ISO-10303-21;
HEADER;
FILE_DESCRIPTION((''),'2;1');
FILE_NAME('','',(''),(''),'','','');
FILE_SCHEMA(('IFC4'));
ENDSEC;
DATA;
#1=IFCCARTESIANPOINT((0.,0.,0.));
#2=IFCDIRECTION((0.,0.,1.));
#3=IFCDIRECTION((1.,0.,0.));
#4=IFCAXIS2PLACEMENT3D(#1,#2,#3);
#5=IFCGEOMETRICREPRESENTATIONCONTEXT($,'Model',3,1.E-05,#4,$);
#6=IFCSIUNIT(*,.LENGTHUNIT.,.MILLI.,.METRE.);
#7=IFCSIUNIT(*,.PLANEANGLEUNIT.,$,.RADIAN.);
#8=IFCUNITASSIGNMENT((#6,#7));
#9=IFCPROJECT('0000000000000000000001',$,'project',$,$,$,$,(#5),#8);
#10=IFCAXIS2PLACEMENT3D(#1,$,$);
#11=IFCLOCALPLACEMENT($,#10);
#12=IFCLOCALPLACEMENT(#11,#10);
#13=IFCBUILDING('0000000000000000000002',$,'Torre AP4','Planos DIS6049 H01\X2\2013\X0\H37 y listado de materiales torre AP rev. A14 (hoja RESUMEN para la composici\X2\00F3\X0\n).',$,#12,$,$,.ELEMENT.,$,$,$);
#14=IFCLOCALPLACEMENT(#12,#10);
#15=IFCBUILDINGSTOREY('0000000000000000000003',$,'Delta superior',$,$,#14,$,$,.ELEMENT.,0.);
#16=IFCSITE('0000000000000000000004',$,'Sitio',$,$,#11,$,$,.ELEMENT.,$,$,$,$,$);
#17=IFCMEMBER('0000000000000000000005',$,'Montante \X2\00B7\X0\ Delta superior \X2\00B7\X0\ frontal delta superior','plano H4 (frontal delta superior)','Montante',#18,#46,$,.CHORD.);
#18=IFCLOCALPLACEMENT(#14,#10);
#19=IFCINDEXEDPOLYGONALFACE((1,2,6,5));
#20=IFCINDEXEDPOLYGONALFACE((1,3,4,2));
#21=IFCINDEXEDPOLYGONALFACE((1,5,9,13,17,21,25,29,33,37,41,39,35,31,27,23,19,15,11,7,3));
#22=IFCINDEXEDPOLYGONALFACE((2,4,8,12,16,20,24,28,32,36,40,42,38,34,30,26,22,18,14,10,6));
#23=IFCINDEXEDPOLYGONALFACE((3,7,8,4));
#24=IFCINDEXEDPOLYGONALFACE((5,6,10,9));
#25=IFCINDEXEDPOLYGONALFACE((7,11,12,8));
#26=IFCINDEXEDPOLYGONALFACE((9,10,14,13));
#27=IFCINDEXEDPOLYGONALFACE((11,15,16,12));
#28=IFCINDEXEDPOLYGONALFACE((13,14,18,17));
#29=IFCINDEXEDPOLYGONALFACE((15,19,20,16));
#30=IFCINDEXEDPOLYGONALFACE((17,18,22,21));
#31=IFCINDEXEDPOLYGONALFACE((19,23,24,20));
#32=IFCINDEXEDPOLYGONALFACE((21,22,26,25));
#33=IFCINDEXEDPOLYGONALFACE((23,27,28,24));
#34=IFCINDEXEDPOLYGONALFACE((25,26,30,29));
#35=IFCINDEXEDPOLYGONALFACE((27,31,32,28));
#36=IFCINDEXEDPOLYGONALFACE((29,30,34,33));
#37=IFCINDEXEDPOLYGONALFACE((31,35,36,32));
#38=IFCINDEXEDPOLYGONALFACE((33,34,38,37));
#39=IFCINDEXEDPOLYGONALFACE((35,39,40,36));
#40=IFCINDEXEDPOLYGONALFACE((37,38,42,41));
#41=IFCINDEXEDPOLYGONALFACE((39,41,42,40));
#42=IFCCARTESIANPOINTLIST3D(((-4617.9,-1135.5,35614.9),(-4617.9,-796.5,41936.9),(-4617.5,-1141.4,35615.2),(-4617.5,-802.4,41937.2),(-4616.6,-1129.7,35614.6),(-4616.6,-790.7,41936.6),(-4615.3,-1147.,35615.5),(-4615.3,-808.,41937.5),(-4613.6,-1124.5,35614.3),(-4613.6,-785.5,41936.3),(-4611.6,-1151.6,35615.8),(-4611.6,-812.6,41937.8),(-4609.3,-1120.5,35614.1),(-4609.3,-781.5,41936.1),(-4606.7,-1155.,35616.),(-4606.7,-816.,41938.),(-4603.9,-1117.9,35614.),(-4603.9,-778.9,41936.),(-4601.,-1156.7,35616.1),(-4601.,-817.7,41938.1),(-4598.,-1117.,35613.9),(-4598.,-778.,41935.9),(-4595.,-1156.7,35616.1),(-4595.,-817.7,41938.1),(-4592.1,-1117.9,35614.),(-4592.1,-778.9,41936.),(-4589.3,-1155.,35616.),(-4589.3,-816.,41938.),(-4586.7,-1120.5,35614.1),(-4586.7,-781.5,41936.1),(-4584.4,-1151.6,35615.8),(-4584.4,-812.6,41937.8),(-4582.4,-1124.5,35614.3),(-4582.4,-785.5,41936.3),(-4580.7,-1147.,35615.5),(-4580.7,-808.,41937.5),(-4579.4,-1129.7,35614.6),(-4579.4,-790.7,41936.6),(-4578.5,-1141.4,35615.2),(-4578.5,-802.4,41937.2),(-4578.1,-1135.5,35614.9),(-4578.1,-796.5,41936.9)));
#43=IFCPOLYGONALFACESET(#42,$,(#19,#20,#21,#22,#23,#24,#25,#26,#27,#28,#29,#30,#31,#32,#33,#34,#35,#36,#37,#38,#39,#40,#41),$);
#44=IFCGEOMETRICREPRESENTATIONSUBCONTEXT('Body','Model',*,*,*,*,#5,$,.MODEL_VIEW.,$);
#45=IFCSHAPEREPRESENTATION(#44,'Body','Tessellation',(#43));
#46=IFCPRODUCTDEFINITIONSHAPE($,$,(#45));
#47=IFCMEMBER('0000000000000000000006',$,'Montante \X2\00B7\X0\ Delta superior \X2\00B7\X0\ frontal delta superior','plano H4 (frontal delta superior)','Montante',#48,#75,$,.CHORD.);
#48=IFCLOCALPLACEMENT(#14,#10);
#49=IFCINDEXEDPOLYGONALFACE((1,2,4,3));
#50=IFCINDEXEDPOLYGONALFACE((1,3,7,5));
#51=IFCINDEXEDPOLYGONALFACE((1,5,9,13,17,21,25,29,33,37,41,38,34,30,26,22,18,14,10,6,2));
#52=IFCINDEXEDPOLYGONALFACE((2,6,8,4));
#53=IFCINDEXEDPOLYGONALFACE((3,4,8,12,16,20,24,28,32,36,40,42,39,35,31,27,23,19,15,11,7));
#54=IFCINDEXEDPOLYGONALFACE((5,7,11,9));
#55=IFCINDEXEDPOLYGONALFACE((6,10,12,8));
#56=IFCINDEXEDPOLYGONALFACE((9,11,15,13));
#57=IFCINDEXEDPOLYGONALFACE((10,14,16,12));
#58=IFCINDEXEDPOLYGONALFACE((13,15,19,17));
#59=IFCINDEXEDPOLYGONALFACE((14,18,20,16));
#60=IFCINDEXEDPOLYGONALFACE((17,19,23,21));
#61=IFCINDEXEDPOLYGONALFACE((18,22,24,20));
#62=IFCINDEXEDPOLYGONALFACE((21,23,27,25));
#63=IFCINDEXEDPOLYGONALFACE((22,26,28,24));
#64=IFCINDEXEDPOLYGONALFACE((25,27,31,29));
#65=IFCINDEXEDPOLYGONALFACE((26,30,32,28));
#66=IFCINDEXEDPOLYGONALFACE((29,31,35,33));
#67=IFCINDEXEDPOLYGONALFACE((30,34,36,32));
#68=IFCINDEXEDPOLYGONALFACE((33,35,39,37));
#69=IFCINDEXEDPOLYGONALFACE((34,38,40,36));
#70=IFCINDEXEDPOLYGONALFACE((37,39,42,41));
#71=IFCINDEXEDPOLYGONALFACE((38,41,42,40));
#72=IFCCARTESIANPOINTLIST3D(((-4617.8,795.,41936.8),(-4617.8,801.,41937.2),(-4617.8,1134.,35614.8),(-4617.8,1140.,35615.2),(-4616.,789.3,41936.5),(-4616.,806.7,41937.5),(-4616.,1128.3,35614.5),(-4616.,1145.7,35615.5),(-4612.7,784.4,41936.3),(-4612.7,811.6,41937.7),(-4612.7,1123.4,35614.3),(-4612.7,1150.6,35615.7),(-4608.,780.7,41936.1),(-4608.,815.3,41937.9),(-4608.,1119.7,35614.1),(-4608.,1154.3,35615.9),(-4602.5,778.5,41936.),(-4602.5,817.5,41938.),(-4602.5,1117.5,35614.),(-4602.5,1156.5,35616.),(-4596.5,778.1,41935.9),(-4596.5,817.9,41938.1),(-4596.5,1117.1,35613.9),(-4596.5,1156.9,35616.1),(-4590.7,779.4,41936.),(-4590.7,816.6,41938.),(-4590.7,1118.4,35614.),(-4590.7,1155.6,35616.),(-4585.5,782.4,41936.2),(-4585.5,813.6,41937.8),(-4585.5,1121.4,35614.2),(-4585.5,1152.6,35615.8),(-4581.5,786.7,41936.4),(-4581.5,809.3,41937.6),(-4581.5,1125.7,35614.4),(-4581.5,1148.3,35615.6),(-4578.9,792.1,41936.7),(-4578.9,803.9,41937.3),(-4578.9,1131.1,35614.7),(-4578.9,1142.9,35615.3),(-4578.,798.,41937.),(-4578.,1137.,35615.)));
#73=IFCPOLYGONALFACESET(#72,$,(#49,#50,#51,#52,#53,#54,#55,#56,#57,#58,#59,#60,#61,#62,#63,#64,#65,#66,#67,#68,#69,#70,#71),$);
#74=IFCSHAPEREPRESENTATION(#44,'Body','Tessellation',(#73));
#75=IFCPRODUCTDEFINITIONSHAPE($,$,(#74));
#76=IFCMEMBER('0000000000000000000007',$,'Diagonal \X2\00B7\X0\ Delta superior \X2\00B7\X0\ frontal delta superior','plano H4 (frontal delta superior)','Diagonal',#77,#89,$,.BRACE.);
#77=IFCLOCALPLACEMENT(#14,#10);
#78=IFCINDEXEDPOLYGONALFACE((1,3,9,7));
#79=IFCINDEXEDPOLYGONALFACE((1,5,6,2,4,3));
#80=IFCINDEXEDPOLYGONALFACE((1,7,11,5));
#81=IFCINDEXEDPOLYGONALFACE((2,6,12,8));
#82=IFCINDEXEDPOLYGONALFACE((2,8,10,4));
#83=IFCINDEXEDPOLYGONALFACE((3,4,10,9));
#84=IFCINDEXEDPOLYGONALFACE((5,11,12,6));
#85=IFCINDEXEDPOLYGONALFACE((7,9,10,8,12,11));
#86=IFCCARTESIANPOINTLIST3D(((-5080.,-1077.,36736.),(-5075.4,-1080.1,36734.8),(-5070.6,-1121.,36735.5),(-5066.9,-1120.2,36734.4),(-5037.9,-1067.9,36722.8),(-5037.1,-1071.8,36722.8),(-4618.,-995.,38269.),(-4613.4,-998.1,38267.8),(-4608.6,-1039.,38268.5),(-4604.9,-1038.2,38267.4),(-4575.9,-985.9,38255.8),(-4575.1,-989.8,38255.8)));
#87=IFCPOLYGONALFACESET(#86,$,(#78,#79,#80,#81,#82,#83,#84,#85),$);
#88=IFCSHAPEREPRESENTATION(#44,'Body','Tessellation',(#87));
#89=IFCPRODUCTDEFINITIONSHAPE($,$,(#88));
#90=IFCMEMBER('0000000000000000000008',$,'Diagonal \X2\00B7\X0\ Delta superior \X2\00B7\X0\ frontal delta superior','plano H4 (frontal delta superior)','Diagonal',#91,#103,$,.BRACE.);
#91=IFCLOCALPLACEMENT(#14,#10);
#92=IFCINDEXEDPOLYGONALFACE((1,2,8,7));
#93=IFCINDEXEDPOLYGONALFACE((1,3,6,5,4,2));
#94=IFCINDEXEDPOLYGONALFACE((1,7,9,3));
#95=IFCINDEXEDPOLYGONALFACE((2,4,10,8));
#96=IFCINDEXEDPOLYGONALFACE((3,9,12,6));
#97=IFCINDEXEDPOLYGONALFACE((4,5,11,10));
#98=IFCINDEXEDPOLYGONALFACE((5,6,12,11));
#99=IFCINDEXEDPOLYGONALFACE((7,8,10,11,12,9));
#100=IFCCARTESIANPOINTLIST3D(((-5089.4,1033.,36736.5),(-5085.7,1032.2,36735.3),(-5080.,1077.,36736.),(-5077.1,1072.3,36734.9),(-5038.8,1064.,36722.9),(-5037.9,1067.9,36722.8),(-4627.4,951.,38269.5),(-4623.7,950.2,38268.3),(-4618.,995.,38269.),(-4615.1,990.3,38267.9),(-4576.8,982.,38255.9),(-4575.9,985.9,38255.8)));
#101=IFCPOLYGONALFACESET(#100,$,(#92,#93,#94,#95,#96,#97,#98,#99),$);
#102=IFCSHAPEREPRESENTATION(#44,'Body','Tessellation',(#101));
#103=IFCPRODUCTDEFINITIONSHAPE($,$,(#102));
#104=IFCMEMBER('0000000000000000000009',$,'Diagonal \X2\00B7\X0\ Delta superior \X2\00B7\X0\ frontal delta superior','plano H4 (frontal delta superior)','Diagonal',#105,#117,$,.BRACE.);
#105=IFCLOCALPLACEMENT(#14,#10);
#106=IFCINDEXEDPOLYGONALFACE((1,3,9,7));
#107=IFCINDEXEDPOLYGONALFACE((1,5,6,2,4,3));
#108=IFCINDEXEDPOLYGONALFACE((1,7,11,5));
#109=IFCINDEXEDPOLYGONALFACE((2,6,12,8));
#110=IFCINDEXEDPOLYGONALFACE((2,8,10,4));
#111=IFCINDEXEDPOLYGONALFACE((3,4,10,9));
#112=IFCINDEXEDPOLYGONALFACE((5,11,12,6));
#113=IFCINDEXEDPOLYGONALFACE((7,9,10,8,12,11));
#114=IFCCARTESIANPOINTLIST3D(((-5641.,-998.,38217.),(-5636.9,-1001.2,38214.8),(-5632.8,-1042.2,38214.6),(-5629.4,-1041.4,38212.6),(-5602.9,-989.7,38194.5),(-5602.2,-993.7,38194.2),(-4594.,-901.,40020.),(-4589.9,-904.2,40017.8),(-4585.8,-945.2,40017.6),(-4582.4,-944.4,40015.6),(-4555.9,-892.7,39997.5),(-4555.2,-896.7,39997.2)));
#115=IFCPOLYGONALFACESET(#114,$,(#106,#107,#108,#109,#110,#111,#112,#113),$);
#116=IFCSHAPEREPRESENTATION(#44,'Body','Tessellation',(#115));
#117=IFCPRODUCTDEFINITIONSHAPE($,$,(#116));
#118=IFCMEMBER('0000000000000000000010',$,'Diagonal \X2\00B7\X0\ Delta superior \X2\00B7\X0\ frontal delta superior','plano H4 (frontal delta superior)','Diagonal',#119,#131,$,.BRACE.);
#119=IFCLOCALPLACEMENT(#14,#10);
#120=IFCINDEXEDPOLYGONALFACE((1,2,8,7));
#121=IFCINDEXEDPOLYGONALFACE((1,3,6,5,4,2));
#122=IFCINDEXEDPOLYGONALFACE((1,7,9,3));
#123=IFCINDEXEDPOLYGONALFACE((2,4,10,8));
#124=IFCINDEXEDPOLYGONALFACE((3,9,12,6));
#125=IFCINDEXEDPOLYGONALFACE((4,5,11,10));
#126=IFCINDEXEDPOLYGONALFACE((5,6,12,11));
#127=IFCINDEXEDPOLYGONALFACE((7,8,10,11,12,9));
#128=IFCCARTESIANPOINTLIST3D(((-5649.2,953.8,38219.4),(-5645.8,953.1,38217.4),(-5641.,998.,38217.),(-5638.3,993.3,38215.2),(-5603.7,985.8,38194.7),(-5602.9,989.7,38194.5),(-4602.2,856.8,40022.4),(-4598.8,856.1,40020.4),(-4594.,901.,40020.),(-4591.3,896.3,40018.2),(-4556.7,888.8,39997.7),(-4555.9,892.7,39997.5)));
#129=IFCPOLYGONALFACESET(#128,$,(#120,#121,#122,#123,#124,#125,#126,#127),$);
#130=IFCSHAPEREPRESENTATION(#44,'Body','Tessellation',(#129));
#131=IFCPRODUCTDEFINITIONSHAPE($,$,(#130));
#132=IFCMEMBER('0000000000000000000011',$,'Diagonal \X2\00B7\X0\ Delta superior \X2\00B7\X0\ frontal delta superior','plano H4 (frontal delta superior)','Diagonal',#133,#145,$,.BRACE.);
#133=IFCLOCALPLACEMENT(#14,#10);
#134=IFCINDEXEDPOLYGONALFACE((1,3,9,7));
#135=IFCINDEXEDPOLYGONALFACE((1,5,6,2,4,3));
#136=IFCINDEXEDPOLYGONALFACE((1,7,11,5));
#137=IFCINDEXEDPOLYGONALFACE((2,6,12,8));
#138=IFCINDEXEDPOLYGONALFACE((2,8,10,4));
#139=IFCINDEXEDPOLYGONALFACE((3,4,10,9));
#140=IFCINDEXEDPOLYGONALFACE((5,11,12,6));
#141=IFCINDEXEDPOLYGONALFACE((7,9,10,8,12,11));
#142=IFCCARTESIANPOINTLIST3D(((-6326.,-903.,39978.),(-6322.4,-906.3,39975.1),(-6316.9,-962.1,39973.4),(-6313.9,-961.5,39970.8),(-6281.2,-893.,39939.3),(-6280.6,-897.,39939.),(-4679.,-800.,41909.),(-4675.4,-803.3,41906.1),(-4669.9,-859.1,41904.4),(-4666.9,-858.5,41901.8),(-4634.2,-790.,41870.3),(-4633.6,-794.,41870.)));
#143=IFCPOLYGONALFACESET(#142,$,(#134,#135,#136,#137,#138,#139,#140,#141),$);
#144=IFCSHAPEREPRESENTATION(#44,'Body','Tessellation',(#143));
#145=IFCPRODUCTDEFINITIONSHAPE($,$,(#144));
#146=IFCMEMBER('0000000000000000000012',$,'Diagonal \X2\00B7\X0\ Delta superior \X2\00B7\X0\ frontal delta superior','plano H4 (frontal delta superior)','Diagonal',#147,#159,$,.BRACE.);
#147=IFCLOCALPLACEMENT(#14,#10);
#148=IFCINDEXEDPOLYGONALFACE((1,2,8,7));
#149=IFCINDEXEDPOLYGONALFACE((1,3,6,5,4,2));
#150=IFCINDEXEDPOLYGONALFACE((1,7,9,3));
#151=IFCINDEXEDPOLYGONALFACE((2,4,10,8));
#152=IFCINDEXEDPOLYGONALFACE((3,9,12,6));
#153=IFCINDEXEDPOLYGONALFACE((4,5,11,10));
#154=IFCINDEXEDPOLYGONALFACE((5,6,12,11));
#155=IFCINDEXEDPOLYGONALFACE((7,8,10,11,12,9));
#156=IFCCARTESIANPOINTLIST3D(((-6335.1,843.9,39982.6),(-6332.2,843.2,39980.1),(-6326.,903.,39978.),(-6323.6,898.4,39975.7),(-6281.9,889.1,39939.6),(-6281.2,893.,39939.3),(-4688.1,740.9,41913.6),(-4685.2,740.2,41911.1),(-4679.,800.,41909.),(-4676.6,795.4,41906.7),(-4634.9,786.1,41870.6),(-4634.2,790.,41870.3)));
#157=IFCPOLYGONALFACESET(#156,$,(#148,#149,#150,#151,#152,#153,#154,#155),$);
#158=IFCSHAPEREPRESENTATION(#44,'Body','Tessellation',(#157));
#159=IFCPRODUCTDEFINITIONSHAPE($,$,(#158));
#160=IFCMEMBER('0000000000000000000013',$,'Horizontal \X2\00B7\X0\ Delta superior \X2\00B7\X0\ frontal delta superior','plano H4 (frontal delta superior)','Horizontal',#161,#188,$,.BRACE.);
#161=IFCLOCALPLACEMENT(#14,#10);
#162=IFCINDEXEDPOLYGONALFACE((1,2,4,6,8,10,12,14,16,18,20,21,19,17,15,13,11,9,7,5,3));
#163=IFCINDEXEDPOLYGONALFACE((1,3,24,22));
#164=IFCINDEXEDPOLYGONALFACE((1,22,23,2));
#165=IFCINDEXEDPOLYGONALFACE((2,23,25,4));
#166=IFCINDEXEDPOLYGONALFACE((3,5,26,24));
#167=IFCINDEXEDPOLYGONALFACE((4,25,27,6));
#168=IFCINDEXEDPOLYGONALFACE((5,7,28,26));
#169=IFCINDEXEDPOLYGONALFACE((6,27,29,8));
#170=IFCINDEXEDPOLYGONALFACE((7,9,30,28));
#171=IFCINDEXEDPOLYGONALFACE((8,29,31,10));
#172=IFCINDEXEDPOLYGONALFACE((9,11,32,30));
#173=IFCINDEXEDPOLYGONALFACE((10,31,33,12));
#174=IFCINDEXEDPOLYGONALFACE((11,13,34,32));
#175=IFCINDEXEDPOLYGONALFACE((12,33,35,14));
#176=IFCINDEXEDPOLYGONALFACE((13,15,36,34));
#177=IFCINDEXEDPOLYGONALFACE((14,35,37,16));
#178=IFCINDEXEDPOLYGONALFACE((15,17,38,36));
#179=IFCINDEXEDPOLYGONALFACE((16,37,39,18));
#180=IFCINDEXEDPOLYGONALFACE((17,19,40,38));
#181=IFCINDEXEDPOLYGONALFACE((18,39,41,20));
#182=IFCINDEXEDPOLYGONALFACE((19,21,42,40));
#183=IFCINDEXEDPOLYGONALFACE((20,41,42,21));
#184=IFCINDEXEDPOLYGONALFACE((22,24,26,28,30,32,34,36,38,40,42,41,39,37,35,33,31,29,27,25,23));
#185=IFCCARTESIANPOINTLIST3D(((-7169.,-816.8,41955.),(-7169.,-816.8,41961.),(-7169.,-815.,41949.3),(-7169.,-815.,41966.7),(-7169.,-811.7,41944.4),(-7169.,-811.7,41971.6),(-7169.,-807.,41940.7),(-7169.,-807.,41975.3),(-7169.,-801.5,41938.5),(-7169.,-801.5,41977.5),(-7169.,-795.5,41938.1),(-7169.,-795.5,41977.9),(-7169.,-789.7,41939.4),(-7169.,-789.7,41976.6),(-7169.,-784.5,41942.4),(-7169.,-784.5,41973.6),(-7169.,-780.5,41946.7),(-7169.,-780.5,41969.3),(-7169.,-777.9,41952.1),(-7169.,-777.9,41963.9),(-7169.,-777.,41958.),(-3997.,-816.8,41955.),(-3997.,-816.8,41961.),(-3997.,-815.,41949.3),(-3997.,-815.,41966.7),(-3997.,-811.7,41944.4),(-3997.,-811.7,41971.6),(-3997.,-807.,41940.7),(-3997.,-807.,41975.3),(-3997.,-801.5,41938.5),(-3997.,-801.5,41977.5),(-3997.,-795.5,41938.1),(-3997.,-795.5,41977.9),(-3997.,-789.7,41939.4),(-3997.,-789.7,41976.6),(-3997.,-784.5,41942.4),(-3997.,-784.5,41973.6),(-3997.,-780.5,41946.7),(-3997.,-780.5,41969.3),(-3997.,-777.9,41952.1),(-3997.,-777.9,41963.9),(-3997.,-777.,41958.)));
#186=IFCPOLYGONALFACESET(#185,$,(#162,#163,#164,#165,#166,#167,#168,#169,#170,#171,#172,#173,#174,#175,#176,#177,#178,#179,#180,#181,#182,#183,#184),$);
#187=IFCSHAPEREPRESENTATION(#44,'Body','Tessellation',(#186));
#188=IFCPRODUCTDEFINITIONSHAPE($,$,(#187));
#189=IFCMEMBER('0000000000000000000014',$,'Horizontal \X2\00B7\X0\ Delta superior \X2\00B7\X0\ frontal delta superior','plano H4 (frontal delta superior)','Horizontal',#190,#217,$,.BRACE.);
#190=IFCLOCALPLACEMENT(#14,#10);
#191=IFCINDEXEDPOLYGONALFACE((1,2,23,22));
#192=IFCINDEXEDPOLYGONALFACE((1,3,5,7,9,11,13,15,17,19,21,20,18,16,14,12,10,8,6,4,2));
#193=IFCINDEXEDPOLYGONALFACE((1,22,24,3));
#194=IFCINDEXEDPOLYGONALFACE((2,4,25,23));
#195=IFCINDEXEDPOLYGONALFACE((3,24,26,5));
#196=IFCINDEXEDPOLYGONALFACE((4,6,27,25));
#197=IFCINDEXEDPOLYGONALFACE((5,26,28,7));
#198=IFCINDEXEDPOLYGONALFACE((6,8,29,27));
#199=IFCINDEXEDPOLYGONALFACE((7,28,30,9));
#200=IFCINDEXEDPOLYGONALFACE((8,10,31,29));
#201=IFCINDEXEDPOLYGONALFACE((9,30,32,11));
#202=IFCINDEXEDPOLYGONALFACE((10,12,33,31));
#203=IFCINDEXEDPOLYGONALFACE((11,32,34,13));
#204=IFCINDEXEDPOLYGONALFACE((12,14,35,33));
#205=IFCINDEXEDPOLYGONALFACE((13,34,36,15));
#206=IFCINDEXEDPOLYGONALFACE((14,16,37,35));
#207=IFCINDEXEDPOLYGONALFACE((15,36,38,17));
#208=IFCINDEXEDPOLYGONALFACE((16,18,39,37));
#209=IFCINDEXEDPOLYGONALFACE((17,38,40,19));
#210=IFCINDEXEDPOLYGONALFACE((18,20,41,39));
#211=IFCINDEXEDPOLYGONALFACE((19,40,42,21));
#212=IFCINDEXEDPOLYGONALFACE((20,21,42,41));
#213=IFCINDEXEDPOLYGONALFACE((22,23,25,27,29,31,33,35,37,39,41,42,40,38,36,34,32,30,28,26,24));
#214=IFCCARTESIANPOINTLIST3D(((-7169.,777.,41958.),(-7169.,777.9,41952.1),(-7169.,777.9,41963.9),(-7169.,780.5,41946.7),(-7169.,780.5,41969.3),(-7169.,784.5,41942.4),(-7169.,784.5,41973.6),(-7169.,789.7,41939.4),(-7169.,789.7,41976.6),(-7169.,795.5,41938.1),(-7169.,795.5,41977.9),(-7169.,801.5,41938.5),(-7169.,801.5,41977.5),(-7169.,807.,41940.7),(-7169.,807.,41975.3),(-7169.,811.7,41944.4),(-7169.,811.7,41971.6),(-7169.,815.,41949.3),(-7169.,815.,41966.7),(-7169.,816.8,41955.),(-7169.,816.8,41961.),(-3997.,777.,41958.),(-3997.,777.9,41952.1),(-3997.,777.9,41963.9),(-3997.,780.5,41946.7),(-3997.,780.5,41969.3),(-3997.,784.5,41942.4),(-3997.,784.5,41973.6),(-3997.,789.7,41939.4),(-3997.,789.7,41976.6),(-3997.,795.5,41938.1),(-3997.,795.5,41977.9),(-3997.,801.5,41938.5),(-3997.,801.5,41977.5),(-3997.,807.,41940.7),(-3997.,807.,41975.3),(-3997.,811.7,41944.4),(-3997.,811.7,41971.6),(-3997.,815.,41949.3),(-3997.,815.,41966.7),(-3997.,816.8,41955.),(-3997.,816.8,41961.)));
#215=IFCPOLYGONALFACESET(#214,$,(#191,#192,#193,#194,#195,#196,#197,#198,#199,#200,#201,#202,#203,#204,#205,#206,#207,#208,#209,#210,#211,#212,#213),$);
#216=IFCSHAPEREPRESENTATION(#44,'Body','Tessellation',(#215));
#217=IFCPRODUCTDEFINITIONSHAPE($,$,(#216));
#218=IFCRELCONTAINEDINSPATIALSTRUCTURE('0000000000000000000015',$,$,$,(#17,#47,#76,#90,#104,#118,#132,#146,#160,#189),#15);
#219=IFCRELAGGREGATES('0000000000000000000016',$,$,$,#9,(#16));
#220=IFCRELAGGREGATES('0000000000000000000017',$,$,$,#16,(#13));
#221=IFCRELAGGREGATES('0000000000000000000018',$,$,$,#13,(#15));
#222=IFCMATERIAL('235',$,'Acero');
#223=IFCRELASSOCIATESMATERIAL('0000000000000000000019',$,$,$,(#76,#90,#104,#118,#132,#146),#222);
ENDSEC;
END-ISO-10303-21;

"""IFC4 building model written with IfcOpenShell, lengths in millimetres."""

from ifc_helpers import new_model, si_unit, frame, frame_2d, origin, origin_with_axes, place, context, subcontext, project, spatial, circle, l_section, extrude, material, element, save


model = new_model("IFC4")

# Units and contexts
model_context = context("Model", 3, precision=1e-05, world=origin_with_axes())
body_context = subcontext(model_context, "Body", "Model", "MODEL_VIEW")
ifc_project = project(units=[si_unit("LENGTHUNIT", "METRE", prefix="MILLI"), si_unit("PLANEANGLEUNIT", "RADIAN")], contexts=[model_context])

# Site, building, storey
site_placement = place(None, origin())
site = spatial("IfcSite", under=ifc_project, at=site_placement, Name="Sitio", CompositionType="ELEMENT")
building_placement = place(site_placement, origin())
building = spatial("IfcBuilding", under=site, at=building_placement, Name="Torre AP4", Description="Planos DIS6049 H01–H37 y listado de materiales torre AP rev. A14 (hoja RESUMEN para la composición).", CompositionType="ELEMENT")
storey_placement = place(building_placement, origin())
storey = spatial("IfcBuildingStorey", under=building, at=storey_placement, Name="Delta superior", CompositionType="ELEMENT", Elevation=0.0)

# Members
for number, where, z_axis, x_axis, name in (
    (1, (-4598.0, -798.0, 41937.0), (0.0, -0.053545, -0.998565), (0.0, 0.998565, -0.053545), "Montante · Delta superior · frontal delta superior"),
    (2, (-4598.0, 798.0, 41937.0), (0.0, 0.053545, -0.998565), (1.0, 0.0, 0.0), "Montante · Delta superior · frontal delta superior"),
):
    element("IfcMember", number, at=place(storey_placement, frame(where, z_axis=z_axis, x_axis=x_axis)), inside=storey, Name=name, Description="plano H4 (frontal delta superior)", ObjectType="Montante", PredefinedType="CHORD", context=body_context, shape_type="SweptSolid", body=[
        extrude(circle(Radius=20.0), None, (0.0, 0.0, 1.0), 6331.1),
    ])
ifc_material_1 = material(Name="235", Category="Acero")
for number, where, z_axis, x_axis, name in (
    (3, (-4618.0, -995.0, 38269.0), (-0.288173, -0.051148, -0.956211), (0.934509, 0.202848, -0.292483), "Diagonal · Delta superior · frontal delta superior"),
    (4, (-4618.0, 995.0, 38269.0), (-0.288173, 0.051148, -0.956211), (0.934509, -0.202848, -0.292483), "Diagonal · Delta superior · frontal delta superior"),
):
    element("IfcMember", number, at=place(storey_placement, frame(where, z_axis=z_axis, x_axis=x_axis)), inside=storey, material=ifc_material_1, Name=name, Description="plano H4 (frontal delta superior)", ObjectType="Diagonal", PredefinedType="BRACE", context=body_context, shape_type="SweptSolid", body=[
        extrude(l_section(Depth=45.0, Width=45.0, Thickness=4.0, at=frame_2d((22.5, 22.5))), None, (0.0, 0.0, 1.0), 1603.2),
    ])
for number, where, z_axis, x_axis, name in (
    (5, (-4594.0, -901.0, 40020.0), (-0.501628, -0.046474, -0.863834), (0.845685, 0.183933, -0.500984), "Diagonal · Delta superior · frontal delta superior"),
    (6, (-4594.0, 901.0, 40020.0), (-0.501628, 0.046474, -0.863834), (0.845685, -0.183933, -0.500984), "Diagonal · Delta superior · frontal delta superior"),
):
    element("IfcMember", number, at=place(storey_placement, frame(where, z_axis=z_axis, x_axis=x_axis)), inside=storey, material=ifc_material_1, Name=name, Description="plano H4 (frontal delta superior)", ObjectType="Diagonal", PredefinedType="BRACE", context=body_context, shape_type="SweptSolid", body=[
        extrude(l_section(Depth=45.0, Width=45.0, Thickness=4.0, at=frame_2d((22.5, 22.5))), None, (0.0, 0.0, 1.0), 2087.2),
    ])
for number, where, z_axis, x_axis, name in (
    (7, (-4679.0, -800.0, 41909.0), (-0.648406, -0.04055, -0.760214), (0.745871, 0.166153, -0.645035), "Diagonal · Delta superior · frontal delta superior"),
    (8, (-4679.0, 800.0, 41909.0), (-0.648406, 0.04055, -0.760214), (0.745871, -0.166153, -0.645035), "Diagonal · Delta superior · frontal delta superior"),
):
    element("IfcMember", number, at=place(storey_placement, frame(where, z_axis=z_axis, x_axis=x_axis)), inside=storey, material=ifc_material_1, Name=name, Description="plano H4 (frontal delta superior)", ObjectType="Diagonal", PredefinedType="BRACE", context=body_context, shape_type="SweptSolid", body=[
        extrude(l_section(Depth=60.0, Width=60.0, Thickness=4.0, at=frame_2d((30.0, 30.0))), None, (0.0, 0.0, 1.0), 2540.1),
    ])
for number, where, z_axis, x_axis, name in (
    (9, (-3997.0, -797.0, 41958.0), (-1.0, 0.0, 0.0), (0.0, 1.0, 0.0), "Horizontal · Delta superior · frontal delta superior"),
    (10, (-3997.0, 797.0, 41958.0), (-1.0, 0.0, 0.0), (0.0, -1.0, 0.0), "Horizontal · Delta superior · frontal delta superior"),
):
    element("IfcMember", number, at=place(storey_placement, frame(where, z_axis=z_axis, x_axis=x_axis)), inside=storey, Name=name, Description="plano H4 (frontal delta superior)", ObjectType="Horizontal", PredefinedType="BRACE", context=body_context, shape_type="SweptSolid", body=[
        extrude(circle(Radius=20.0), None, (0.0, 0.0, 1.0), 3172.0),
    ])

save(model, "model.ifc")
